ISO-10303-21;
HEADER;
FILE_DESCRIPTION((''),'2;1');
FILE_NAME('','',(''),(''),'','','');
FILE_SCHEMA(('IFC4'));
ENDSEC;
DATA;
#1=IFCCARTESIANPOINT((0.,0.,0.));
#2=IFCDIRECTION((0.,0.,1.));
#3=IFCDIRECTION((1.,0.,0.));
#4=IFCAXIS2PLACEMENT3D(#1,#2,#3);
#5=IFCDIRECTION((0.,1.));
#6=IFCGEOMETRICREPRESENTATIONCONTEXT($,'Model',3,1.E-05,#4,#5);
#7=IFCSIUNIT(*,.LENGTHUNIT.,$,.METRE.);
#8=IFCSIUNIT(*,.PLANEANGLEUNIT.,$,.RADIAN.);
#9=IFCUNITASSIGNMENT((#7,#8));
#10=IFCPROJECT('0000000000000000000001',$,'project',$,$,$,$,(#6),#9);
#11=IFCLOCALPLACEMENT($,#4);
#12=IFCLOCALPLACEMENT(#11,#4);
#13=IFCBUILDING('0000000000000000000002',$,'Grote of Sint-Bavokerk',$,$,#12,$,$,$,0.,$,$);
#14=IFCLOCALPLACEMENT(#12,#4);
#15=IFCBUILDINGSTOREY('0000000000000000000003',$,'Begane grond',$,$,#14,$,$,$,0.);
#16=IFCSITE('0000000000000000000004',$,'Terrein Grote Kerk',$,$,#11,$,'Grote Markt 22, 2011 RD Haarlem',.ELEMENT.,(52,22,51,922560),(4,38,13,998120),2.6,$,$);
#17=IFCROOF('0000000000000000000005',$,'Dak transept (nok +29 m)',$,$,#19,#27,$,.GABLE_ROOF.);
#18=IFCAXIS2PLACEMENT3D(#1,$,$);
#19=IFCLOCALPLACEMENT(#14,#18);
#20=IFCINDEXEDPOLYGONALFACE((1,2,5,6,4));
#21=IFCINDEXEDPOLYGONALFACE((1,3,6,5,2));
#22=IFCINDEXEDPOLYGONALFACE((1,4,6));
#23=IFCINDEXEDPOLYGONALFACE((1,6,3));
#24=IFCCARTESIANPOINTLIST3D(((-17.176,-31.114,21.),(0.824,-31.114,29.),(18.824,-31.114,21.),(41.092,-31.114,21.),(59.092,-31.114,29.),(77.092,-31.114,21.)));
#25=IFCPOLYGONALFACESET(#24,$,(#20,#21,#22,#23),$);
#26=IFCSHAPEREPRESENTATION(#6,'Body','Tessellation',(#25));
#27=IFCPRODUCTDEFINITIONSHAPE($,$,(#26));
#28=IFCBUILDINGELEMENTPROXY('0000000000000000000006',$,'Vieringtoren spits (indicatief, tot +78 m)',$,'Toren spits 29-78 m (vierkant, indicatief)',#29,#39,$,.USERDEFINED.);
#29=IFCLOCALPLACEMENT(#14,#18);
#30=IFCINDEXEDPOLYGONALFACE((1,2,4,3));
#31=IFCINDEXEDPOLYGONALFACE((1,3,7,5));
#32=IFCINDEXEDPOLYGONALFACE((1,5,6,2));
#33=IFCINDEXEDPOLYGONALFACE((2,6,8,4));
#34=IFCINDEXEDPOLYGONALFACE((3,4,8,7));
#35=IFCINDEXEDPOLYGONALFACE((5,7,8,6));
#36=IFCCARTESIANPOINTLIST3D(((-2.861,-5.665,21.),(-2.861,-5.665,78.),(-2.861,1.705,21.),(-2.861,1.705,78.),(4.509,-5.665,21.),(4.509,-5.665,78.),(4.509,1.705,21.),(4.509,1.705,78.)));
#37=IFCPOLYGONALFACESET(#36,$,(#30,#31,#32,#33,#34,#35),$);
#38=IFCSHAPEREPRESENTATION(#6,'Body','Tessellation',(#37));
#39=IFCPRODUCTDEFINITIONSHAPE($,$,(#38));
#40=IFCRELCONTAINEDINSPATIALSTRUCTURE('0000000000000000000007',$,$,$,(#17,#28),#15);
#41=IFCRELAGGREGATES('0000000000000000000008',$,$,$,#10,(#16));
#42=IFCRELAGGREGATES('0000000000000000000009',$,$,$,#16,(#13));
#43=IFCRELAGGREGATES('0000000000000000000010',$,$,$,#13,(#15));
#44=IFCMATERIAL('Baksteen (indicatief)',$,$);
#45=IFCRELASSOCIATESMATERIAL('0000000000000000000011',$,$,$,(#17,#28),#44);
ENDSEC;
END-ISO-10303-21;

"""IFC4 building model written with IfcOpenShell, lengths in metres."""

from ifc_helpers import new_model, si_unit, direction, frame, origin_with_axes, place, context, project, spatial, indexed_curve, outline, extrude, material, element, save


model = new_model("IFC4")

# Units and contexts
model_context = context("Model", 3, precision=1e-05, world=origin_with_axes(), true_north=direction((0.0, 1.0)))
ifc_project = project(units=[si_unit("LENGTHUNIT", "METRE"), si_unit("PLANEANGLEUNIT", "RADIAN")], contexts=[model_context])

# Site, building, storey
site_placement = place(None, origin_with_axes())
site = spatial("IfcSite", under=ifc_project, at=site_placement, Name="Terrein Grote Kerk", LongName="Grote Markt 22, 2011 RD Haarlem", CompositionType="ELEMENT", RefLatitude=(52, 22, 51, 922560), RefLongitude=(4, 38, 13, 998120), RefElevation=2.6)
building_placement = place(site_placement, origin_with_axes())
building = spatial("IfcBuilding", under=site, at=building_placement, Name="Grote of Sint-Bavokerk", ElevationOfRefHeight=0.0)
storey_placement = place(building_placement, origin_with_axes())
storey = spatial("IfcBuildingStorey", under=building, at=storey_placement, Name="Begane grond", Elevation=0.0)

# Shared definitions
ifc_material = material(Name="Baksteen (indicatief)")

# Roof
roof_1_placement = place(storey_placement, origin_with_axes())
element("IfcRoof", 1, at=roof_1_placement, inside=storey, material=ifc_material, Name="Dak transept (nok +29 m)", PredefinedType="GABLE_ROOF", context=model_context, shape_type="SweptSolid", body=[
    extrude(outline(indexed_curve([(21.0, 18.0), (29.0, 0.0), (21.0, -18.0), (21.0, 18.0)])), frame((0.824, -31.114, 0.0), z_axis=(0.0, 1.0, 0.0), x_axis=(0.0, 0.0, 1.0)), (0.0, 1.0, 0.0), 58.268),
])

# Building element proxy
proxy_placement = place(storey_placement, origin_with_axes())
element("IfcBuildingElementProxy", 2, at=proxy_placement, inside=storey, material=ifc_material, Name="Vieringtoren spits (indicatief, tot +78 m)", ObjectType="Toren spits 29-78 m (vierkant, indicatief)", PredefinedType="USERDEFINED", context=model_context, shape_type="SweptSolid", body=[
    extrude(outline(indexed_curve([(-2.861, -5.665), (4.509, -5.665), (4.509, 1.705), (-2.861, 1.705), (-2.861, -5.665)])), frame((0.0, 0.0, 21.0), z_axis=(0.0, 0.0, 1.0), x_axis=(1.0, 0.0, 0.0)), (0.0, 0.0, 1.0), 57.0),
])

save(model, "model.ifc")
